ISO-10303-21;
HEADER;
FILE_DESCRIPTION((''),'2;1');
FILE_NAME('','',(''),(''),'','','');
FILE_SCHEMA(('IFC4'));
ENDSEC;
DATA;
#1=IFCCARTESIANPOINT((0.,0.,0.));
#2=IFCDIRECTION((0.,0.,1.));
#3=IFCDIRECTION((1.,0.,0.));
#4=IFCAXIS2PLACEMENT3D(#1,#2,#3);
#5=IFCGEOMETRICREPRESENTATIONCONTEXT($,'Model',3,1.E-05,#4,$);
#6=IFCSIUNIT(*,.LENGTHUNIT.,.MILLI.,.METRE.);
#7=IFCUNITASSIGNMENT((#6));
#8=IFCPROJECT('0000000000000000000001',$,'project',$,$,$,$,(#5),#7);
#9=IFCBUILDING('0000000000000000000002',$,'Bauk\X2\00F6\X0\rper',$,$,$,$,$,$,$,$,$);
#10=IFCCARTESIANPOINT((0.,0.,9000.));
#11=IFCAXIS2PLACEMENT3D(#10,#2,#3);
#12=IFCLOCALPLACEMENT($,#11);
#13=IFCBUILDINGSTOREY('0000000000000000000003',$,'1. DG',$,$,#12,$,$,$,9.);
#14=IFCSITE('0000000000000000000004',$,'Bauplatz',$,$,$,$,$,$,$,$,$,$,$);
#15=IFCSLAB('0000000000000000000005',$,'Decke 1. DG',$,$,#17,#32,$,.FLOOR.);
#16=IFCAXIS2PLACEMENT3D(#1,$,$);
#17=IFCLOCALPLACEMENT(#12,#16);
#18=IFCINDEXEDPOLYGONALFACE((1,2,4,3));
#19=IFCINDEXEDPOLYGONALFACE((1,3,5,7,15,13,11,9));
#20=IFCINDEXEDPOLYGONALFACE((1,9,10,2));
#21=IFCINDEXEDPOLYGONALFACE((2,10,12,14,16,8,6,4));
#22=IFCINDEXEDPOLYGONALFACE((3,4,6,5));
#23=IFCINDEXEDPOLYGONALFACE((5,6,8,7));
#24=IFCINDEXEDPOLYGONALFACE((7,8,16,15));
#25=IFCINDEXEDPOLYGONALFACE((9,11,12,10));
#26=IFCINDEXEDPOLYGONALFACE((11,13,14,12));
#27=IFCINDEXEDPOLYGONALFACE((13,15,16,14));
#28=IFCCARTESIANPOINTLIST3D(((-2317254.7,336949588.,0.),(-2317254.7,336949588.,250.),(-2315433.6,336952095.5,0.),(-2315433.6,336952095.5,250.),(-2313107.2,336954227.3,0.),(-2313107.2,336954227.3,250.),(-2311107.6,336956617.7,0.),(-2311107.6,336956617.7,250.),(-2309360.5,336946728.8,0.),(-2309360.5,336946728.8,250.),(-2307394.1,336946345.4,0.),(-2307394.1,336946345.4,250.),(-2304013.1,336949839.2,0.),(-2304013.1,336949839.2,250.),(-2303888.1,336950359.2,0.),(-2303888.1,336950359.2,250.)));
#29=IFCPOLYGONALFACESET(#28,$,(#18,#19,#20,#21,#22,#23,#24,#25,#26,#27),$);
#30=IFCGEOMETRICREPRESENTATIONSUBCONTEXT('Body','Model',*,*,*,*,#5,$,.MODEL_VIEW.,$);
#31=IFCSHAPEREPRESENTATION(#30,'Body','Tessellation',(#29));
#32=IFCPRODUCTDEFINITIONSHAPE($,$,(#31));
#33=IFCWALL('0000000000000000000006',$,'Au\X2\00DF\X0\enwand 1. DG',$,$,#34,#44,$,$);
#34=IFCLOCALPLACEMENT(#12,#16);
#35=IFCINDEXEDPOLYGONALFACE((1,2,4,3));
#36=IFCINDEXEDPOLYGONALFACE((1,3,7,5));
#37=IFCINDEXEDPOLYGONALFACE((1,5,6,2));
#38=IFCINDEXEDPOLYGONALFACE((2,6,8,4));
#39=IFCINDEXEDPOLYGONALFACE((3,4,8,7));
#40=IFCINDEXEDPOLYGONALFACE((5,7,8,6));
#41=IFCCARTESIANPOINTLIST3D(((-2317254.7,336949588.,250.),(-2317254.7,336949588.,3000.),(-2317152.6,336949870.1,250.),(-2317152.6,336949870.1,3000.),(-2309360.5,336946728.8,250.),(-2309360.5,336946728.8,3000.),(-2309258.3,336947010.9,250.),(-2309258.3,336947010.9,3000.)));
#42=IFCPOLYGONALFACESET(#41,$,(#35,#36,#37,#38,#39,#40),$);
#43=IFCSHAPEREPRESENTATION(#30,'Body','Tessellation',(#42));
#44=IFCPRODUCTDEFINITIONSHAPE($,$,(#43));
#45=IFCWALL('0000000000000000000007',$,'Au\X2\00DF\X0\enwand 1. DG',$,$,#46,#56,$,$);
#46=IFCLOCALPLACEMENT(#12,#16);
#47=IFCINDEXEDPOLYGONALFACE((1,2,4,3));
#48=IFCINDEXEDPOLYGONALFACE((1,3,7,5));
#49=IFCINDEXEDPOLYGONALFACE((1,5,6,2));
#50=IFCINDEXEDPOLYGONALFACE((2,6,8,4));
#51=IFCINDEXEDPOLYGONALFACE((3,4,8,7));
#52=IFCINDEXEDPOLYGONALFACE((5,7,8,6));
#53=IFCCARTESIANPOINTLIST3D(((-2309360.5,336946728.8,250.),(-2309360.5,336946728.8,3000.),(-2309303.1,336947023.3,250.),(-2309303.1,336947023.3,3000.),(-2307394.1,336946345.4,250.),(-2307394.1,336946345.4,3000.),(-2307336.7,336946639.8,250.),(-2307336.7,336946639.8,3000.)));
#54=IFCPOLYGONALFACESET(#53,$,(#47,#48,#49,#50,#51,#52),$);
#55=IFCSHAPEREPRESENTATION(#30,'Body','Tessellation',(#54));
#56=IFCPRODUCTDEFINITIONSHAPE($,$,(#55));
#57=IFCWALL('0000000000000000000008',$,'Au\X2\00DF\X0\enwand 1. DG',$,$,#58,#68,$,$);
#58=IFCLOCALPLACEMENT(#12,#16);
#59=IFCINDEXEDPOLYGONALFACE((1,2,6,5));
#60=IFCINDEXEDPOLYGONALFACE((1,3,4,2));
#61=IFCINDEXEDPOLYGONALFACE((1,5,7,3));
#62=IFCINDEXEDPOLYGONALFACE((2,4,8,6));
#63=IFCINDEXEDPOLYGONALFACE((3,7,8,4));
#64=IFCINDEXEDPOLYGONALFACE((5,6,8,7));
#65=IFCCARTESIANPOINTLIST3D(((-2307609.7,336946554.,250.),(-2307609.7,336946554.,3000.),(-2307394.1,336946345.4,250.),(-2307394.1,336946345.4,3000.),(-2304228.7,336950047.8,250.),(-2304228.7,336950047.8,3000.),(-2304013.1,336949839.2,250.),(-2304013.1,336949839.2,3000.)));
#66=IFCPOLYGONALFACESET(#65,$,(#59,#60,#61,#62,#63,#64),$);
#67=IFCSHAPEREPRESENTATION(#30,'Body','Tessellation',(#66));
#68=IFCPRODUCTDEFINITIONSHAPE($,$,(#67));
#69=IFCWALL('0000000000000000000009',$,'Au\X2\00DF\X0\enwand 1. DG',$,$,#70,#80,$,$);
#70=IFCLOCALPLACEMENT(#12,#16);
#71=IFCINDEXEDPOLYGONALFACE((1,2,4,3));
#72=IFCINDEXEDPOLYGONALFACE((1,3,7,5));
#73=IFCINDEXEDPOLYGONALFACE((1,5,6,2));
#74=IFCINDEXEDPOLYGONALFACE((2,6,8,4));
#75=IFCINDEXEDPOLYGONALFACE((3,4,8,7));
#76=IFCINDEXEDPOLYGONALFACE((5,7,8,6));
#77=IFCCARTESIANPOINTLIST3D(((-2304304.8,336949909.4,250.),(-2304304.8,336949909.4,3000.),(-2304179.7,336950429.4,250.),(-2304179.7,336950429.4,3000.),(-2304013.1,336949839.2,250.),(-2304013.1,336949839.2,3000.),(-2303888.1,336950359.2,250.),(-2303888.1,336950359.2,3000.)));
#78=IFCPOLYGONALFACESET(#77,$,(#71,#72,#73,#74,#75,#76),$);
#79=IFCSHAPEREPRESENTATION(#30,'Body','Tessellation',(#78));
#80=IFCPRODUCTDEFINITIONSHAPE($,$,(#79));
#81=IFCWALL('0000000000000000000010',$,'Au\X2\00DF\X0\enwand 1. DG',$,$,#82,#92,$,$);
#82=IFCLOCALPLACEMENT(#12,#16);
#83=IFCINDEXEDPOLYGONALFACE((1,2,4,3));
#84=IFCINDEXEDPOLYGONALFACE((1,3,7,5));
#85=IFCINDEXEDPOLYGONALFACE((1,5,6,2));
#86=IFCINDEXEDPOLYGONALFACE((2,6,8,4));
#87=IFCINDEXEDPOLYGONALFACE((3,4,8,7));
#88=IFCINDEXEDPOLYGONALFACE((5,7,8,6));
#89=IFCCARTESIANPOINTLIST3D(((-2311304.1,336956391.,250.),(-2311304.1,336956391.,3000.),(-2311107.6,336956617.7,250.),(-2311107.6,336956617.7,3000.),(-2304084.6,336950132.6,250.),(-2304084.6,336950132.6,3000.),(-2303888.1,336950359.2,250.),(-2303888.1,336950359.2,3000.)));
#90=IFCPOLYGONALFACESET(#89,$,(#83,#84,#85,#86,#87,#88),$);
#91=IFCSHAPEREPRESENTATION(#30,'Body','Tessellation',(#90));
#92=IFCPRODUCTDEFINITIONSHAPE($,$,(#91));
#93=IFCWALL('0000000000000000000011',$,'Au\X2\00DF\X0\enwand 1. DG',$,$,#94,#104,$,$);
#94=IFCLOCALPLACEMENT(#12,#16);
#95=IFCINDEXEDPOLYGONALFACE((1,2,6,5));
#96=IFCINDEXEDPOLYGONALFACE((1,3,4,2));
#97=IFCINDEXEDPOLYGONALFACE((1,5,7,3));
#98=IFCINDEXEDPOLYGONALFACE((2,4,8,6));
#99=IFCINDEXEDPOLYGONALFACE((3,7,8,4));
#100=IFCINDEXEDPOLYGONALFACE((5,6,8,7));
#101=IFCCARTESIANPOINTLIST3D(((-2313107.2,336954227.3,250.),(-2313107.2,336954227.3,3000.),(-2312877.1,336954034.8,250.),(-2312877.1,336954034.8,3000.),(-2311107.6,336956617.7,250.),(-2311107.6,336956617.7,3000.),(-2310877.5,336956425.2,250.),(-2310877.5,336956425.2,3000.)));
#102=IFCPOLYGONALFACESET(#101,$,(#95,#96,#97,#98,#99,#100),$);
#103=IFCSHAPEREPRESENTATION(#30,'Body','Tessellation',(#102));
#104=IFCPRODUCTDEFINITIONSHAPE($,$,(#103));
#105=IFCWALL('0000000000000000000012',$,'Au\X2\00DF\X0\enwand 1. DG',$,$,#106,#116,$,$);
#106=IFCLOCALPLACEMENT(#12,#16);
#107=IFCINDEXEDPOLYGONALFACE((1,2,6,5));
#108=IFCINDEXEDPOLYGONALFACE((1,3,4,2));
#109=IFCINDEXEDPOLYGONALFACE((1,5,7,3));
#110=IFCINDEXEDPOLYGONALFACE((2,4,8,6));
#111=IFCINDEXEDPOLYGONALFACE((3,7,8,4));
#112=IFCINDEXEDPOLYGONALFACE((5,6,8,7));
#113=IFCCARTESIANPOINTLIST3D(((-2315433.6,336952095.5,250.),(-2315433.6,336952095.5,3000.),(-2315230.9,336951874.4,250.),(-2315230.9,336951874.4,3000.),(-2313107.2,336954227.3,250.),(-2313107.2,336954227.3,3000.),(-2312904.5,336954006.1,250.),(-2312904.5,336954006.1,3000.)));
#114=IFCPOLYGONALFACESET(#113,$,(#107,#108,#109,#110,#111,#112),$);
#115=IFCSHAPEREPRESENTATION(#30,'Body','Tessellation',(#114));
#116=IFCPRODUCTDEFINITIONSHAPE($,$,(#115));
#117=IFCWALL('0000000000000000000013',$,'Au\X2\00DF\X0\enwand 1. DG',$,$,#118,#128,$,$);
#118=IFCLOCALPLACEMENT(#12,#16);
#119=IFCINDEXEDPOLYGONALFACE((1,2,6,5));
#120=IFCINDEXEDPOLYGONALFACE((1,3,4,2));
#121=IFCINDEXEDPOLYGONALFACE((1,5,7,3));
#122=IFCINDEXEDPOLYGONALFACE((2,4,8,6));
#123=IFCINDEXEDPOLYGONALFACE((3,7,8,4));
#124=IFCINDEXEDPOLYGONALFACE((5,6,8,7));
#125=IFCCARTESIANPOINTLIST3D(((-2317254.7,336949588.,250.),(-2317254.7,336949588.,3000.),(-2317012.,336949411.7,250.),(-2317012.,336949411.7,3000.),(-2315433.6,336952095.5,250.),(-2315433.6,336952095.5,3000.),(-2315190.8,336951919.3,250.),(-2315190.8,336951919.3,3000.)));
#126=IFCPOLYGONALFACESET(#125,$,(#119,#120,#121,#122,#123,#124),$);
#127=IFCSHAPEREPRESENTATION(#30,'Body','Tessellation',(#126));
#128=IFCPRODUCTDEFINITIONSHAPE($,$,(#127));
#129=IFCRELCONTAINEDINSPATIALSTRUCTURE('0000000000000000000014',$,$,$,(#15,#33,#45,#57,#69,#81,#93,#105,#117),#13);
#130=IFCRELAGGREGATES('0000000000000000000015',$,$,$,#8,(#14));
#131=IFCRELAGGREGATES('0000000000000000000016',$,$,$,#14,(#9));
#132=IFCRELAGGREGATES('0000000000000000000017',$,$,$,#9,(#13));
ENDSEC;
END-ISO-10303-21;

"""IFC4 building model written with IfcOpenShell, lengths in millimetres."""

from ifc_helpers import new_model, si_unit, frame, origin_with_axes, place, context, subcontext, project, spatial, indexed_curve, outline, extrude, element, save


model = new_model("IFC4")

# Units and contexts
model_context = context("Model", 3, precision=1e-05, world=origin_with_axes())
body_context = subcontext(model_context, "Body", "Model", "MODEL_VIEW")
ifc_project = project(units=[si_unit("LENGTHUNIT", "METRE", prefix="MILLI")], contexts=[model_context])

# Site, building, storey
site = spatial("IfcSite", under=ifc_project, Name="Bauplatz")
building = spatial("IfcBuilding", under=site, Name="Baukörper")
storey_placement = place(None, frame((0.0, 0.0, 9000.0), z_axis=(0.0, 0.0, 1.0), x_axis=(1.0, 0.0, 0.0)))
storey = spatial("IfcBuildingStorey", under=building, at=storey_placement, Name="1. DG", Elevation=9.0)

# Slab
slab_placement = place(storey_placement, origin_with_axes())
element("IfcSlab", 1, at=slab_placement, inside=storey, Name="Decke 1. DG", PredefinedType="FLOOR", context=body_context, shape_type="SweptSolid", body=[
    extrude(outline(indexed_curve([(-2317254.7, 336949588.0), (-2315433.6, 336952095.5), (-2313107.2, 336954227.3), (-2311107.6, 336956617.7), (-2303888.1, 336950359.2), (-2304013.1, 336949839.2), (-2307394.1, 336946345.4), (-2309360.5, 336946728.8)])), None, (0.0, 0.0, 1.0), 250.0),
])

# Walls
wall_1_placement = place(storey_placement, frame((-2317254.7, 336949588.0, 250.0), z_axis=(0.0, 0.0, 1.0), x_axis=(0.94023, -0.340539, 0.0)))
element("IfcWall", 2, at=wall_1_placement, inside=storey, Name="Außenwand 1. DG", context=body_context, shape_type="SweptSolid", body=[
    extrude(outline(indexed_curve([(0.0, 0.0), (0.0, 300.0), (8396.1, 300.0), (8396.1, 0.0), (0.0, 0.0)], self_intersect=False)), origin_with_axes(), (0.0, 0.0, 1.0), 2750.0),
])
wall_2_placement = place(storey_placement, frame((-2309360.5, 336946728.8, 250.0), z_axis=(0.0, 0.0, 1.0), x_axis=(0.981513, -0.191395, 0.0)))
element("IfcWall", 3, at=wall_2_placement, inside=storey, Name="Außenwand 1. DG", context=body_context, shape_type="SweptSolid", body=[
    extrude(outline(indexed_curve([(0.0, 0.0), (0.0, 300.0), (2003.4, 300.0), (2003.4, 0.0), (0.0, 0.0)], self_intersect=False)), origin_with_axes(), (0.0, 0.0, 1.0), 2750.0),
])
wall_3_placement = place(storey_placement, frame((-2307394.1, 336946345.4, 250.0), z_axis=(0.0, 0.0, 1.0), x_axis=(0.6954, 0.718623, 0.0)))
element("IfcWall", 4, at=wall_3_placement, inside=storey, Name="Außenwand 1. DG", context=body_context, shape_type="SweptSolid", body=[
    extrude(outline(indexed_curve([(0.0, 0.0), (0.0, 300.0), (4861.9, 300.0), (4861.9, 0.0), (0.0, 0.0)], self_intersect=False)), origin_with_axes(), (0.0, 0.0, 1.0), 2750.0),
])
wall_4_placement = place(storey_placement, frame((-2304013.1, 336949839.2, 250.0), z_axis=(0.0, 0.0, 1.0), x_axis=(0.233838, 0.972275, 0.0)))
element("IfcWall", 5, at=wall_4_placement, inside=storey, Name="Außenwand 1. DG", context=body_context, shape_type="SweptSolid", body=[
    extrude(outline(indexed_curve([(0.0, 0.0), (0.0, 300.0), (534.9, 300.0), (534.9, 0.0), (0.0, 0.0)], self_intersect=False)), origin_with_axes(), (0.0, 0.0, 1.0), 2750.0),
])
wall_5_placement = place(storey_placement, frame((-2303888.1, 336950359.2, 250.0), z_axis=(0.0, 0.0, 1.0), x_axis=(-0.75561, 0.655022, 0.0)))
element("IfcWall", 6, at=wall_5_placement, inside=storey, Name="Außenwand 1. DG", context=body_context, shape_type="SweptSolid", body=[
    extrude(outline(indexed_curve([(0.0, 0.0), (0.0, 300.0), (9554.6, 300.0), (9554.6, 0.0), (0.0, 0.0)], self_intersect=False)), origin_with_axes(), (0.0, 0.0, 1.0), 2750.0),
])
wall_6_placement = place(storey_placement, frame((-2311107.6, 336956617.7, 250.0), z_axis=(0.0, 0.0, 1.0), x_axis=(-0.641607, -0.767034, 0.0)))
element("IfcWall", 7, at=wall_6_placement, inside=storey, Name="Außenwand 1. DG", context=body_context, shape_type="SweptSolid", body=[
    extrude(outline(indexed_curve([(0.0, 0.0), (0.0, 300.0), (3116.5, 300.0), (3116.5, 0.0), (0.0, 0.0)], self_intersect=False)), origin_with_axes(), (0.0, 0.0, 1.0), 2750.0),
])
wall_7_placement = place(storey_placement, frame((-2313107.2, 336954227.3, 250.0), z_axis=(0.0, 0.0, 1.0), x_axis=(-0.737282, -0.675585, 0.0)))
element("IfcWall", 8, at=wall_7_placement, inside=storey, Name="Außenwand 1. DG", context=body_context, shape_type="SweptSolid", body=[
    extrude(outline(indexed_curve([(0.0, 0.0), (0.0, 300.0), (3155.4, 300.0), (3155.4, 0.0), (0.0, 0.0)], self_intersect=False)), origin_with_axes(), (0.0, 0.0, 1.0), 2750.0),
])
wall_8_placement = place(storey_placement, frame((-2315433.6, 336952095.5, 250.0), z_axis=(0.0, 0.0, 1.0), x_axis=(-0.587634, -0.809127, 0.0)))
element("IfcWall", 9, at=wall_8_placement, inside=storey, Name="Außenwand 1. DG", context=body_context, shape_type="SweptSolid", body=[
    extrude(outline(indexed_curve([(0.0, 0.0), (0.0, 300.0), (3099.1, 300.0), (3099.1, 0.0), (0.0, 0.0)], self_intersect=False)), origin_with_axes(), (0.0, 0.0, 1.0), 2750.0),
])

save(model, "model.ifc")
